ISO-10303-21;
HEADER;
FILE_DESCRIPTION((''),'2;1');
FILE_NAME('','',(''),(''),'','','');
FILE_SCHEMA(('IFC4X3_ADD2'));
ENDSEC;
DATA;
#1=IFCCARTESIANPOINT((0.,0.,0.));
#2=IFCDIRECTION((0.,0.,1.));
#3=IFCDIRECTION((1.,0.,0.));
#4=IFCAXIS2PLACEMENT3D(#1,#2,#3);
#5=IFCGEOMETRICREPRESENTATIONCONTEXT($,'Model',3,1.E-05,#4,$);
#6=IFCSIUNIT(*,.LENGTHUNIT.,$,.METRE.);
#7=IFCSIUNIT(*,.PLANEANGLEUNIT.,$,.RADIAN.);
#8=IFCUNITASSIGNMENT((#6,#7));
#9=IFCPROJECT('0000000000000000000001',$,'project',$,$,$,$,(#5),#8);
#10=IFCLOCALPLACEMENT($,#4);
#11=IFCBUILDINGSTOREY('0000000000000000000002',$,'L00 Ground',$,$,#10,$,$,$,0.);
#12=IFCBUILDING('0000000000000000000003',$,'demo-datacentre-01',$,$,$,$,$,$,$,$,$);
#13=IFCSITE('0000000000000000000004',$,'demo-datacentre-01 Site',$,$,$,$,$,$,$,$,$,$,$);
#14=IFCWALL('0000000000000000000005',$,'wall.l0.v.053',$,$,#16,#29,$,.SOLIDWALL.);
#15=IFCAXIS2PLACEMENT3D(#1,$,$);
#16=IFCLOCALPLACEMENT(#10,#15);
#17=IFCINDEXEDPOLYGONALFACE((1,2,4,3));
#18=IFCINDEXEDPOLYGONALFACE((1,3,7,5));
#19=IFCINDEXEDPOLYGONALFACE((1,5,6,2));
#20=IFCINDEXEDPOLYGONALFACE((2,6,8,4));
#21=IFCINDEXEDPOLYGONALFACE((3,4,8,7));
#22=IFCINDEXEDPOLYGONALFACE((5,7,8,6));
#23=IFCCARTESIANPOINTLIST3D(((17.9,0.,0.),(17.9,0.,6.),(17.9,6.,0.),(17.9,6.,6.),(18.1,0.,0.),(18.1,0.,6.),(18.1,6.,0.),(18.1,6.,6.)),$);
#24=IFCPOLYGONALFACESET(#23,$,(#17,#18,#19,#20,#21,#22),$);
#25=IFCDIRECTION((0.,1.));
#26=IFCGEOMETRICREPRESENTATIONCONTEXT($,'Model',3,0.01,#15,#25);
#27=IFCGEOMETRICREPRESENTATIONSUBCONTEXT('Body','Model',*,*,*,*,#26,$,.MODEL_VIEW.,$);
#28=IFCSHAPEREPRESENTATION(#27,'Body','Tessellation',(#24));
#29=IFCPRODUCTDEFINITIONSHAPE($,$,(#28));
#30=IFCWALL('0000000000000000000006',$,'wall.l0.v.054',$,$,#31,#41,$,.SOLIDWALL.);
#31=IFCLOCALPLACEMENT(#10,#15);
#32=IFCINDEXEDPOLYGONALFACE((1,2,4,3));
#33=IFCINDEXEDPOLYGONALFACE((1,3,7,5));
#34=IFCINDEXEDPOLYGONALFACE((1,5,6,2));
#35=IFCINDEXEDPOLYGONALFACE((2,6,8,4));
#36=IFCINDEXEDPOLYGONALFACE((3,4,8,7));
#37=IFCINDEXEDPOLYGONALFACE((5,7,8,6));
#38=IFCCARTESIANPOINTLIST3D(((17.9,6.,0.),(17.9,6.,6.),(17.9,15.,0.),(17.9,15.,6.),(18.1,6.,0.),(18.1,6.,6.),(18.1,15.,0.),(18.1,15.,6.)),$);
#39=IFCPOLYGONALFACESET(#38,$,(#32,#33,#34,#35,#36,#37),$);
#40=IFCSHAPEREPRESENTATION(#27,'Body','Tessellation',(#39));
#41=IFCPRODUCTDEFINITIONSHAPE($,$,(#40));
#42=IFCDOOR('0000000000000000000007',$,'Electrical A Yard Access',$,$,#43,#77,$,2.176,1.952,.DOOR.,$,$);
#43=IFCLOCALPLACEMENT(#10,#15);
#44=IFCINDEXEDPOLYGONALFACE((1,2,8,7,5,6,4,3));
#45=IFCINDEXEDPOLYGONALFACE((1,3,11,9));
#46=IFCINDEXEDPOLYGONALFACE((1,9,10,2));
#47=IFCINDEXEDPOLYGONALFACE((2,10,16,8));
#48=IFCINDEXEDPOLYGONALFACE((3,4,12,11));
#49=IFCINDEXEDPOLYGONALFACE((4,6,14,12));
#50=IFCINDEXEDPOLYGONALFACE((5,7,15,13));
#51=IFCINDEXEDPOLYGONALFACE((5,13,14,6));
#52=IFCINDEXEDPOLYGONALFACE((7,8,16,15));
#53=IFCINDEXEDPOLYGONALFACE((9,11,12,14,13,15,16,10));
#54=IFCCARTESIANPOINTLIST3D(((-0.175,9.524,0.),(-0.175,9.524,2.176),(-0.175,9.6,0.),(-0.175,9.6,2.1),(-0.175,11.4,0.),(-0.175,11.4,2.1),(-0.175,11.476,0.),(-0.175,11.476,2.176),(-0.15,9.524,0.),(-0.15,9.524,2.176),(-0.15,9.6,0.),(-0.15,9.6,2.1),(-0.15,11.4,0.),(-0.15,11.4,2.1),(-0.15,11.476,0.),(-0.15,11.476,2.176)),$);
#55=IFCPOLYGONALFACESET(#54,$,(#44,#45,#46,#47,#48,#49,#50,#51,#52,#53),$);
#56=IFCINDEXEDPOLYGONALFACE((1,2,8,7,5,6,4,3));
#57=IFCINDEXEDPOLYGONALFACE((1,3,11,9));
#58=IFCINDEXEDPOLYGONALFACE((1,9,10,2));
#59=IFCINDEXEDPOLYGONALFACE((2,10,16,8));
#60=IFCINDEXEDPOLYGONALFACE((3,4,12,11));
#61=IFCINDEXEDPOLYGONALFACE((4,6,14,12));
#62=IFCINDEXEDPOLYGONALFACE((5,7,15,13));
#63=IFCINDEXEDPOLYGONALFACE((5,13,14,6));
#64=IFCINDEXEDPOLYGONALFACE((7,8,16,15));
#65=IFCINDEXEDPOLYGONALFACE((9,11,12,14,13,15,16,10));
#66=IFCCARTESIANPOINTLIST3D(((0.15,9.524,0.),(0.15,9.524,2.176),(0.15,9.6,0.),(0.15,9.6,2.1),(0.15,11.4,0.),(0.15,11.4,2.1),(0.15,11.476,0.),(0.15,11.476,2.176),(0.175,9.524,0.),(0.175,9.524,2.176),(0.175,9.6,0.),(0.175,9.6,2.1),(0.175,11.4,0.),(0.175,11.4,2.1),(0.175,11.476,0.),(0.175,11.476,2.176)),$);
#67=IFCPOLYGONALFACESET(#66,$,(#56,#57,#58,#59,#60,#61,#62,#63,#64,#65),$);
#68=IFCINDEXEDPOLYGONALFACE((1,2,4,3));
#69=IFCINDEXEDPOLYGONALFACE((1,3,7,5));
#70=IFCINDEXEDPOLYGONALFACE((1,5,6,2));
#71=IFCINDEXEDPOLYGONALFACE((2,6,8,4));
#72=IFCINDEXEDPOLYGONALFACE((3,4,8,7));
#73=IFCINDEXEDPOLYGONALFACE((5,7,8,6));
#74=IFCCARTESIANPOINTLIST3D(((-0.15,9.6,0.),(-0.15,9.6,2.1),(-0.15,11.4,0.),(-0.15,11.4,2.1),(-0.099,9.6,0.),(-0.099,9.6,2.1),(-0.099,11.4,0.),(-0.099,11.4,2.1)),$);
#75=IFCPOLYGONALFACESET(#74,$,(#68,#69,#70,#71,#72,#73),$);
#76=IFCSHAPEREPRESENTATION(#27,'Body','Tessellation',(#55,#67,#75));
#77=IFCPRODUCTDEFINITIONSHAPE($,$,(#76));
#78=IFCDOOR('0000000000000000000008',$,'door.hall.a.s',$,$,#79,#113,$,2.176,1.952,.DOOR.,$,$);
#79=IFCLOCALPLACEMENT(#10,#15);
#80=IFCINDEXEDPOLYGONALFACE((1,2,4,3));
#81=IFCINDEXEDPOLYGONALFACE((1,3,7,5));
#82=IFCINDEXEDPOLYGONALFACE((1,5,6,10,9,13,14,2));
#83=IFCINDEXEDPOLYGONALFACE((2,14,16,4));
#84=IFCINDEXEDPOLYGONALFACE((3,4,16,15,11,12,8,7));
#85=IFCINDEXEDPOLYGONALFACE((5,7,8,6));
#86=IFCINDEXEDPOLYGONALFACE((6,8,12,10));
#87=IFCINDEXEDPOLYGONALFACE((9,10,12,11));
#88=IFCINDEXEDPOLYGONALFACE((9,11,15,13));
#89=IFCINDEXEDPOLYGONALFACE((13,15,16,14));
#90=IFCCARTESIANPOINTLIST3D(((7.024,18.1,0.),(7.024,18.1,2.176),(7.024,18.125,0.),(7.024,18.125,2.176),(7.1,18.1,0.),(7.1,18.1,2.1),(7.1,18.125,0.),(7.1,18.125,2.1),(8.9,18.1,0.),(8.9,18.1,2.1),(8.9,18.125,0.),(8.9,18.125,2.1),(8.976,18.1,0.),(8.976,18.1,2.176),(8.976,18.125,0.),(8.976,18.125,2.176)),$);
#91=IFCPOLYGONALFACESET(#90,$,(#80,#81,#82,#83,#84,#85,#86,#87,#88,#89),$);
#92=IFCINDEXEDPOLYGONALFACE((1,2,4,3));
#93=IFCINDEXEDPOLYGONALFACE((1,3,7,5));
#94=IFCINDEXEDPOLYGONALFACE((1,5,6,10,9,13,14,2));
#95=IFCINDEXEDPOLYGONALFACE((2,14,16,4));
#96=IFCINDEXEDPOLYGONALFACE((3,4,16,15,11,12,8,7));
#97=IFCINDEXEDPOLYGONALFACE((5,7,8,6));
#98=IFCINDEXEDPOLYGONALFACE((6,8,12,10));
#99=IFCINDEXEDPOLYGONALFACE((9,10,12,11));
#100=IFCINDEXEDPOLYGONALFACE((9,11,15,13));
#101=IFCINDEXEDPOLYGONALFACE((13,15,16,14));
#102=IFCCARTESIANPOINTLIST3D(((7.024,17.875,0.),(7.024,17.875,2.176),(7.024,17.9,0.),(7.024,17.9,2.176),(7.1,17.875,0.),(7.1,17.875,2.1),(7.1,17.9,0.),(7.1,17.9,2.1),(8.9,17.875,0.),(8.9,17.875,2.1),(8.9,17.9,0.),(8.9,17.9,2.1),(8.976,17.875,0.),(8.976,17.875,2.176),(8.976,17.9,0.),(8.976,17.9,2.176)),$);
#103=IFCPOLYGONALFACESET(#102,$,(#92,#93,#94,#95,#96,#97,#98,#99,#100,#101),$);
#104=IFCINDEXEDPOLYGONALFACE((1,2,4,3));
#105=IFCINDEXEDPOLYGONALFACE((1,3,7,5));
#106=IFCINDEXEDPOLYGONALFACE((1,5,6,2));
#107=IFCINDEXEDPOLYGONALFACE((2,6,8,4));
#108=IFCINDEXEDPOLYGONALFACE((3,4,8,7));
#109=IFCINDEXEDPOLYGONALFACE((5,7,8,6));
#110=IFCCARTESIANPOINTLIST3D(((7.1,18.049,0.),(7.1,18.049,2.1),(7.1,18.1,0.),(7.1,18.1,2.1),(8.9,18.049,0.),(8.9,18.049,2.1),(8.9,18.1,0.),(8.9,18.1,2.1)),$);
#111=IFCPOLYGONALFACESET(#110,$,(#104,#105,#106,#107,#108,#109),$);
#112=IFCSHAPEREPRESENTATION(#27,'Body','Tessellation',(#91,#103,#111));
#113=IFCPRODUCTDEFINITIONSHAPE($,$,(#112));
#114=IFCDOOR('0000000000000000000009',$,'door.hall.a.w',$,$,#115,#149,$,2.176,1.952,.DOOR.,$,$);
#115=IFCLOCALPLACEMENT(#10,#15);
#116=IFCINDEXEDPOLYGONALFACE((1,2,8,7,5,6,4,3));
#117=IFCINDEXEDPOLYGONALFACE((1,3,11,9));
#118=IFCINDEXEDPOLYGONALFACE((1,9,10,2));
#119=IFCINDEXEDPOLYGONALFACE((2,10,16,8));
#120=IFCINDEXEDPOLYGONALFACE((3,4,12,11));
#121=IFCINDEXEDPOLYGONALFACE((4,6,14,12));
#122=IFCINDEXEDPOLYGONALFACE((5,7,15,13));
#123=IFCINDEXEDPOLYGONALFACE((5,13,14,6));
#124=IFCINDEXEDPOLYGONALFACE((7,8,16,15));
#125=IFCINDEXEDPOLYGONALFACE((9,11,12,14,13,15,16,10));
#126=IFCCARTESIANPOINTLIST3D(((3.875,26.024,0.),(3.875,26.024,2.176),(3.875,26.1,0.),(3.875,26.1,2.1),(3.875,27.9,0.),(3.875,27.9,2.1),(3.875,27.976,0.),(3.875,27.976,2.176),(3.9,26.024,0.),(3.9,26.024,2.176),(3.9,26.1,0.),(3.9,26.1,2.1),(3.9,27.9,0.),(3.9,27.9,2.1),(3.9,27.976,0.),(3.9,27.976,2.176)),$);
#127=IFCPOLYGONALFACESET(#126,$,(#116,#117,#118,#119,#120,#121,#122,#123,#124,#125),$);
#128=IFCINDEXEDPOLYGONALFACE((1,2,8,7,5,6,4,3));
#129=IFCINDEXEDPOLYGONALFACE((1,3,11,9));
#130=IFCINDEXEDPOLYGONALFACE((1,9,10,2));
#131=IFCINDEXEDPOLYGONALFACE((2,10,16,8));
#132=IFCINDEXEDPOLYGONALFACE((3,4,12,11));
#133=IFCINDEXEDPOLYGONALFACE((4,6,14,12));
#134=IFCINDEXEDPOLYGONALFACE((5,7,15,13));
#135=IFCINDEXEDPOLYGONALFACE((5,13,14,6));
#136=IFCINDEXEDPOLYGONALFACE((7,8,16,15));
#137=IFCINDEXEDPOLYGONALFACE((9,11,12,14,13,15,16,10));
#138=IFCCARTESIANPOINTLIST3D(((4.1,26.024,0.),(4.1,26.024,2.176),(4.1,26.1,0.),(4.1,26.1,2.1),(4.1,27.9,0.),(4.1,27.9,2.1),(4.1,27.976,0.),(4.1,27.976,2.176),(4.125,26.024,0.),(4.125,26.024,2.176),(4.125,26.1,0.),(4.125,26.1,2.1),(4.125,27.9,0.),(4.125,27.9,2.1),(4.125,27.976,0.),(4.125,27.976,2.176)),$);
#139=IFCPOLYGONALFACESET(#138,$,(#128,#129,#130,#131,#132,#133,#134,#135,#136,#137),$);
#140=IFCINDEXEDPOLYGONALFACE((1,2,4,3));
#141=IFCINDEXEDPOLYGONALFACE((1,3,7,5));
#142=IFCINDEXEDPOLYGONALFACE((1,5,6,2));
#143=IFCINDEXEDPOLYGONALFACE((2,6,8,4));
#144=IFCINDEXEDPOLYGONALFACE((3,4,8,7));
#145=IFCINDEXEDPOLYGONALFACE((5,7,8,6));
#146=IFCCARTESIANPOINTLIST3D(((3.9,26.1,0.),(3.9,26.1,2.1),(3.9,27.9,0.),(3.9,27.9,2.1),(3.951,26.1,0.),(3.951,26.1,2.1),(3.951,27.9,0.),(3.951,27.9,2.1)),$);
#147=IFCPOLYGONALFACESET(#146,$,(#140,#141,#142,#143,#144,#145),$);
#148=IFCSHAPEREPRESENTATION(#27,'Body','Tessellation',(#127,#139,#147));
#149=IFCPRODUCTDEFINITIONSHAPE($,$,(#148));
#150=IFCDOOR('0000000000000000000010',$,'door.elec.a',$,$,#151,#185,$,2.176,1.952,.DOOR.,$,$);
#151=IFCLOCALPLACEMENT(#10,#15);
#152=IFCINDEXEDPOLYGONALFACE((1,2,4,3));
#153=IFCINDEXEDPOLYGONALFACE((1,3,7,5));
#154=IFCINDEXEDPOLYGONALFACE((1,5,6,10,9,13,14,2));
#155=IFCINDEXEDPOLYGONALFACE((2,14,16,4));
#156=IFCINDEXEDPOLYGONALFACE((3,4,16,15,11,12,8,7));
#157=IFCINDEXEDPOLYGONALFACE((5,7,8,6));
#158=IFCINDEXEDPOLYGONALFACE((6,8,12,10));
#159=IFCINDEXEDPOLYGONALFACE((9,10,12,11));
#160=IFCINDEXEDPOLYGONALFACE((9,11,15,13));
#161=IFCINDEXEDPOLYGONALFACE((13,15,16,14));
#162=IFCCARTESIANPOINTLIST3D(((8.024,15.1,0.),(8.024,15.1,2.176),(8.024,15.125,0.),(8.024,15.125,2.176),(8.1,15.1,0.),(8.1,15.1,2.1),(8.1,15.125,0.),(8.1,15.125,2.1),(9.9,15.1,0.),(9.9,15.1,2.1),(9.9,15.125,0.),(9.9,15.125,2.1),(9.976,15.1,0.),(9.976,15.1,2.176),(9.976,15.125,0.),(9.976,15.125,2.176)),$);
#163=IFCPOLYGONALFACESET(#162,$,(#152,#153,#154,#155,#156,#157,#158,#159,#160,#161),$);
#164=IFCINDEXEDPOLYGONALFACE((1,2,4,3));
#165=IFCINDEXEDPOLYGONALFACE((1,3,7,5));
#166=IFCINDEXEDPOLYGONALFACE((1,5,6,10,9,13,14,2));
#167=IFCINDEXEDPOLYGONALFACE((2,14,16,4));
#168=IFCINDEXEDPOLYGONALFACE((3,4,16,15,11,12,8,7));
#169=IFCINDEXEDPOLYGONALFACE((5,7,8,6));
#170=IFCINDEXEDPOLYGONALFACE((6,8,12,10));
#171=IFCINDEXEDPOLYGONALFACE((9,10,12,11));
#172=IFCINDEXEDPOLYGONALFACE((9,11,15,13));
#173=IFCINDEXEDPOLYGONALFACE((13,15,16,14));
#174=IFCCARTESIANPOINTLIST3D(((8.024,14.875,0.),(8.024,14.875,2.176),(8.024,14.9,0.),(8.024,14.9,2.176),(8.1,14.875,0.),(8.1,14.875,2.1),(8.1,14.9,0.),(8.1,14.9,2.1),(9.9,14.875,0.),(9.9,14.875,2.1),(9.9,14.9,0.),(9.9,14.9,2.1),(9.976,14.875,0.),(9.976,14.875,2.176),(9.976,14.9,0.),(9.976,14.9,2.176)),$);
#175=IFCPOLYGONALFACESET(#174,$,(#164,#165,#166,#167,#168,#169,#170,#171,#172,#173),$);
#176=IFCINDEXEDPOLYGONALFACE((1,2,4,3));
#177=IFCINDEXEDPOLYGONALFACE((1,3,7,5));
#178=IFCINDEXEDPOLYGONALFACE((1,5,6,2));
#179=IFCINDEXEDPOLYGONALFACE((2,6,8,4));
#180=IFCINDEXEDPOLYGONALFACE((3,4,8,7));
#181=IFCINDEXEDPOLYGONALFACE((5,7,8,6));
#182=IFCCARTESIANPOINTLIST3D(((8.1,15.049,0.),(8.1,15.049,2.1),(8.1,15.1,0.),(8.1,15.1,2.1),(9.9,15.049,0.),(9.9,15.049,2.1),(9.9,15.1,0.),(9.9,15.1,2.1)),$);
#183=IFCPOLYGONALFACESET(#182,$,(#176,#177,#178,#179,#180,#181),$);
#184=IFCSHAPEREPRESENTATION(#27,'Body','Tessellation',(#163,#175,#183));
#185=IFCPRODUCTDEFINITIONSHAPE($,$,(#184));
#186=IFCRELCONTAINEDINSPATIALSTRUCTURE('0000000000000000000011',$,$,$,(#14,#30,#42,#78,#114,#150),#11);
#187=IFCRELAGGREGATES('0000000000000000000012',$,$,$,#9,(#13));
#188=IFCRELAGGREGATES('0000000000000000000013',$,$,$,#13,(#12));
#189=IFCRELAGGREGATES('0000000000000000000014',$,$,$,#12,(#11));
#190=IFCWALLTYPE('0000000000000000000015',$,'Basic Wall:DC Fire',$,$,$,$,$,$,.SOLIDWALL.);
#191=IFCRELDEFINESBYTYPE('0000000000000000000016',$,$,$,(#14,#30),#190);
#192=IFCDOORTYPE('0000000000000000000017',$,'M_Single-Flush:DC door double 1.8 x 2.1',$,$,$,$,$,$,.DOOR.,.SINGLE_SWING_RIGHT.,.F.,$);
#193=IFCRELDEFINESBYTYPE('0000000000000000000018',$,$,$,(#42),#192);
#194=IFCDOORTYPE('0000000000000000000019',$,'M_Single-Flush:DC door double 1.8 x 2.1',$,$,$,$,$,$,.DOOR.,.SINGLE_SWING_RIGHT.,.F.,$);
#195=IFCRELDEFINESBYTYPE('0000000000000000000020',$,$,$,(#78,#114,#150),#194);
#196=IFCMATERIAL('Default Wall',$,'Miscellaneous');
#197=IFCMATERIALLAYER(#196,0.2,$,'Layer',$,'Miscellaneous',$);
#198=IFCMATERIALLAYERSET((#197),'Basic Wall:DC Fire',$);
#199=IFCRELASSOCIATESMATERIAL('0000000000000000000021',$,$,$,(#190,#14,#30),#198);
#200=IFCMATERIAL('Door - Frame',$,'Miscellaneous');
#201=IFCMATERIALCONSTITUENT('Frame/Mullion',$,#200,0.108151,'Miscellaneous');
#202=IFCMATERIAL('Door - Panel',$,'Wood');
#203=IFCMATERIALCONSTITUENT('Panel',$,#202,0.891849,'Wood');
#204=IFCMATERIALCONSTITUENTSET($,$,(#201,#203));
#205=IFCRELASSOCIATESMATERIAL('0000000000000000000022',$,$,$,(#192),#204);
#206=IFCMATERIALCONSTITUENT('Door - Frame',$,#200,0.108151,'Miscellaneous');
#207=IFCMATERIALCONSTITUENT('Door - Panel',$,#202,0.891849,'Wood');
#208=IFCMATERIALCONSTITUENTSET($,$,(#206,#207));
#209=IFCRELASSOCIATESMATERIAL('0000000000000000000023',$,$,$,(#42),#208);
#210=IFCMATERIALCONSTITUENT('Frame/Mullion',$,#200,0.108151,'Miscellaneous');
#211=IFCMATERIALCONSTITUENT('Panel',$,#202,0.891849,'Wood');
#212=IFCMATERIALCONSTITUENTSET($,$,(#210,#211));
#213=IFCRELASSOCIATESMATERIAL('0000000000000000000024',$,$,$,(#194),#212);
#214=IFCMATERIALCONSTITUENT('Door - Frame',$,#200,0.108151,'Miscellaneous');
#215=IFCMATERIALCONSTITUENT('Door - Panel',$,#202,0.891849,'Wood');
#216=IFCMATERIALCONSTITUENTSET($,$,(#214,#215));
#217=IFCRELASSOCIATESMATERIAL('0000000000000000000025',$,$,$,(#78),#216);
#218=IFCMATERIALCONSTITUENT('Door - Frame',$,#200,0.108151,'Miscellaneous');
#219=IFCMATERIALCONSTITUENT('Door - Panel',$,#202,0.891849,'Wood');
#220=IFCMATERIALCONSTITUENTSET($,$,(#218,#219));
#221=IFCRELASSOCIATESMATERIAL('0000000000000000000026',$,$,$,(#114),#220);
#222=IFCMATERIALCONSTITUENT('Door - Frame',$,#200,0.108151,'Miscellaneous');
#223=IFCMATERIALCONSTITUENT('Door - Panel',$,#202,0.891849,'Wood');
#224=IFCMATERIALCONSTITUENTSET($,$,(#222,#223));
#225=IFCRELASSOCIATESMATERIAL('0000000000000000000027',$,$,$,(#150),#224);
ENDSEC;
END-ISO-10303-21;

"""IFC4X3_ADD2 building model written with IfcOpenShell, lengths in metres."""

from ifc_helpers import new_model, si_unit, direction, frame, frame_2d, origin, origin_with_axes, place, context, subcontext, project, spatial, polyline, rectangle, outline, extrude, source, transform, mapped, material, layer, layer_set, constituent, constituent_set, type_object, type_shapes, element, save


model = new_model("IFC4X3_ADD2")

# Units and contexts
model_context_1 = context("Model", 3, precision=0.01, world=origin(), true_north=direction((0.0, 1.0)))
model_context_2 = context("Model", 3, precision=1e-05, world=origin_with_axes())
body_context = subcontext(model_context_1, "Body", "Model", "MODEL_VIEW")
ifc_project = project(units=[si_unit("LENGTHUNIT", "METRE"), si_unit("PLANEANGLEUNIT", "RADIAN")], contexts=[model_context_2])

# Site, building, storey
site = spatial("IfcSite", under=ifc_project, Name="demo-datacentre-01 Site")
building = spatial("IfcBuilding", under=site, Name="demo-datacentre-01")
storey_placement = place(None, origin_with_axes())
storey = spatial("IfcBuildingStorey", under=building, at=storey_placement, Name="L00 Ground", Elevation=0.0)

# Walls
ifc_material_1 = material(Name="Default Wall", Category="Miscellaneous")
placement_1 = place(None, origin())
placement_2 = place(placement_1, origin())
placement_3 = place(placement_2, origin())
ifc_layer_1 = layer(ifc_material_1, 0.2, Name="Layer", Category="Miscellaneous")
ifc_layer_set_1 = layer_set([ifc_layer_1], Name="Basic Wall:DC Fire")
wall_type_1 = type_object("IfcWallType", Name="Basic Wall:DC Fire", PredefinedType="SOLIDWALL", material=ifc_layer_set_1)
wall_1_placement = place(placement_3, frame((18.0, 0.0, 0.0), z_axis=(0.0, 0.0, 1.0), x_axis=(0.0, 1.0, 0.0)))
element("IfcWall", 1, at=wall_1_placement, inside=storey, type_object=wall_type_1, material=ifc_layer_set_1, Name="wall.l0.v.053", PredefinedType="SOLIDWALL", context=body_context, shape_type="SweptSolid", body=[
    extrude(rectangle(XDim=6.0, YDim=0.2, at=frame_2d((3.0, 0.0), x_axis=(-1.0, 0.0))), origin(), (0.0, 0.0, 1.0), 6.0),
])
wall_2_placement = place(placement_3, frame((18.0, 6.0, 0.0), z_axis=(0.0, 0.0, 1.0), x_axis=(0.0, 1.0, 0.0)))
element("IfcWall", 2, at=wall_2_placement, inside=storey, type_object=wall_type_1, material=ifc_layer_set_1, Name="wall.l0.v.054", PredefinedType="SOLIDWALL", context=body_context, shape_type="SweptSolid", body=[
    extrude(rectangle(XDim=9.0, YDim=0.2, at=frame_2d((4.5, 0.0), x_axis=(-1.0, 0.0))), origin(), (0.0, 0.0, 1.0), 6.0),
])

# Doors
ifc_material_2 = material(Name="Door - Frame", Category="Miscellaneous")
ifc_constituent_1 = constituent(ifc_material_2, Name="Door - Frame", Category="Miscellaneous", fraction=0.108151)
ifc_material_3 = material(Name="Door - Panel", Category="Wood")
ifc_constituent_2 = constituent(ifc_material_3, Name="Door - Panel", Category="Wood", fraction=0.891849)
ifc_constituent_set_1 = constituent_set(constituents=[ifc_constituent_1, ifc_constituent_2])
ifc_constituent_3 = constituent(ifc_material_2, Name="Frame/Mullion", Category="Miscellaneous", fraction=0.108151)
ifc_constituent_4 = constituent(ifc_material_3, Name="Panel", Category="Wood", fraction=0.891849)
ifc_constituent_set_2 = constituent_set(constituents=[ifc_constituent_3, ifc_constituent_4])
door_type_1 = type_object("IfcDoorType", Name="M_Single-Flush:DC door double 1.8 x 2.1", OperationType="SINGLE_SWING_RIGHT", ParameterTakesPrecedence=False, PredefinedType="DOOR", material=ifc_constituent_set_2)
shared_shape_1 = source(origin(), body_context, "Body", "SweptSolid", [
    extrude(outline(polyline([(-0.976, -1.107), (0.976, -1.107), (0.976, 1.069), (0.9, 1.069), (0.9, -1.031), (-0.9, -1.031), (-0.9, 1.069), (-0.976, 1.069), (-0.976, -1.107)])), frame((0.9, 0.3, 1.069), z_axis=(0.0, 1.0, 0.0), x_axis=(1.0, 0.0, 0.0)), (0.0, 0.0, 1.0), 0.025),
    extrude(outline(polyline([(-1.107, -0.976), (1.069, -0.976), (1.069, -0.9), (-1.031, -0.9), (-1.031, 0.9), (1.069, 0.9), (1.069, 0.976), (-1.107, 0.976), (-1.107, -0.976)])), frame((0.9, -0.025, 1.069), z_axis=(0.0, 1.0, 0.0), x_axis=(0.0, 0.0, -1.0)), (0.0, 0.0, 1.0), 0.025),
    extrude(rectangle(XDim=0.051, YDim=1.8, at=frame_2d((0.0, 0.0), x_axis=(1.0, 0.0))), frame((0.9, 0.2745, 0.0), z_axis=(0.0, 0.0, 1.0), x_axis=(0.0, 1.0, 0.0)), (0.0, 0.0, 1.0), 2.1),
])
type_shapes(door_type_1, [shared_shape_1])
door_1_placement = place(placement_3, frame((0.15, 9.6, 0.0), z_axis=(0.0, 0.0, 1.0), x_axis=(0.0, 1.0, 0.0)))
element("IfcDoor", 3, at=door_1_placement, inside=storey, type_object=door_type_1, material=ifc_constituent_set_1, Name="Electrical A Yard Access", OverallHeight=2.176, OverallWidth=1.952, PredefinedType="DOOR", context=body_context, shape_type="MappedRepresentation", body=[
    mapped(shared_shape_1, transform((0.0, 0.0, 0.0), scale=1.0)),
])
ifc_constituent_5 = constituent(ifc_material_2, Name="Door - Frame", Category="Miscellaneous", fraction=0.108151)
ifc_constituent_6 = constituent(ifc_material_3, Name="Door - Panel", Category="Wood", fraction=0.891849)
ifc_constituent_set_3 = constituent_set(constituents=[ifc_constituent_5, ifc_constituent_6])
ifc_constituent_7 = constituent(ifc_material_2, Name="Frame/Mullion", Category="Miscellaneous", fraction=0.108151)
ifc_constituent_8 = constituent(ifc_material_3, Name="Panel", Category="Wood", fraction=0.891849)
ifc_constituent_set_4 = constituent_set(constituents=[ifc_constituent_7, ifc_constituent_8])
door_type_2 = type_object("IfcDoorType", Name="M_Single-Flush:DC door double 1.8 x 2.1", OperationType="SINGLE_SWING_RIGHT", ParameterTakesPrecedence=False, PredefinedType="DOOR", material=ifc_constituent_set_4)
shared_shape_2 = source(origin(), body_context, "Body", "SweptSolid", [
    extrude(outline(polyline([(-0.976, -1.107), (0.976, -1.107), (0.976, 1.069), (0.9, 1.069), (0.9, -1.031), (-0.9, -1.031), (-0.9, 1.069), (-0.976, 1.069), (-0.976, -1.107)])), frame((0.9, 0.2, 1.069), z_axis=(0.0, 1.0, 0.0), x_axis=(1.0, 0.0, 0.0)), (0.0, 0.0, 1.0), 0.025),
    extrude(outline(polyline([(-1.107, -0.976), (1.069, -0.976), (1.069, -0.9), (-1.031, -0.9), (-1.031, 0.9), (1.069, 0.9), (1.069, 0.976), (-1.107, 0.976), (-1.107, -0.976)])), frame((0.9, -0.025, 1.069), z_axis=(0.0, 1.0, 0.0), x_axis=(0.0, 0.0, -1.0)), (0.0, 0.0, 1.0), 0.025),
    extrude(rectangle(XDim=0.051, YDim=1.8, at=frame_2d((0.0, 0.0), x_axis=(1.0, 0.0))), frame((0.9, 0.1745, 0.0), z_axis=(0.0, 0.0, 1.0), x_axis=(0.0, 1.0, 0.0)), (0.0, 0.0, 1.0), 2.1),
])
type_shapes(door_type_2, [shared_shape_2])
door_2_placement = place(placement_3, frame((7.1, 17.9, 0.0)))
element("IfcDoor", 4, at=door_2_placement, inside=storey, type_object=door_type_2, material=ifc_constituent_set_3, Name="door.hall.a.s", OverallHeight=2.176, OverallWidth=1.952, PredefinedType="DOOR", context=body_context, shape_type="MappedRepresentation", body=[
    mapped(shared_shape_2, transform((0.0, 0.0, 0.0), scale=1.0)),
])
ifc_constituent_9 = constituent(ifc_material_2, Name="Door - Frame", Category="Miscellaneous", fraction=0.108151)
ifc_constituent_10 = constituent(ifc_material_3, Name="Door - Panel", Category="Wood", fraction=0.891849)
ifc_constituent_set_5 = constituent_set(constituents=[ifc_constituent_9, ifc_constituent_10])
door_3_placement = place(placement_3, frame((4.1, 26.1, 0.0), z_axis=(0.0, 0.0, 1.0), x_axis=(0.0, 1.0, 0.0)))
element("IfcDoor", 5, at=door_3_placement, inside=storey, type_object=door_type_2, material=ifc_constituent_set_5, Name="door.hall.a.w", OverallHeight=2.176, OverallWidth=1.952, PredefinedType="DOOR", context=body_context, shape_type="MappedRepresentation", body=[
    mapped(shared_shape_2, transform((0.0, 0.0, 0.0), scale=1.0)),
])
ifc_constituent_11 = constituent(ifc_material_2, Name="Door - Frame", Category="Miscellaneous", fraction=0.108151)
ifc_constituent_12 = constituent(ifc_material_3, Name="Door - Panel", Category="Wood", fraction=0.891849)
ifc_constituent_set_6 = constituent_set(constituents=[ifc_constituent_11, ifc_constituent_12])
door_4_placement = place(placement_3, frame((8.1, 14.9, 0.0)))
element("IfcDoor", 6, at=door_4_placement, inside=storey, type_object=door_type_2, material=ifc_constituent_set_6, Name="door.elec.a", OverallHeight=2.176, OverallWidth=1.952, PredefinedType="DOOR", context=body_context, shape_type="MappedRepresentation", body=[
    mapped(shared_shape_2, transform((0.0, 0.0, 0.0), scale=1.0)),
])

save(model, "model.ifc")
